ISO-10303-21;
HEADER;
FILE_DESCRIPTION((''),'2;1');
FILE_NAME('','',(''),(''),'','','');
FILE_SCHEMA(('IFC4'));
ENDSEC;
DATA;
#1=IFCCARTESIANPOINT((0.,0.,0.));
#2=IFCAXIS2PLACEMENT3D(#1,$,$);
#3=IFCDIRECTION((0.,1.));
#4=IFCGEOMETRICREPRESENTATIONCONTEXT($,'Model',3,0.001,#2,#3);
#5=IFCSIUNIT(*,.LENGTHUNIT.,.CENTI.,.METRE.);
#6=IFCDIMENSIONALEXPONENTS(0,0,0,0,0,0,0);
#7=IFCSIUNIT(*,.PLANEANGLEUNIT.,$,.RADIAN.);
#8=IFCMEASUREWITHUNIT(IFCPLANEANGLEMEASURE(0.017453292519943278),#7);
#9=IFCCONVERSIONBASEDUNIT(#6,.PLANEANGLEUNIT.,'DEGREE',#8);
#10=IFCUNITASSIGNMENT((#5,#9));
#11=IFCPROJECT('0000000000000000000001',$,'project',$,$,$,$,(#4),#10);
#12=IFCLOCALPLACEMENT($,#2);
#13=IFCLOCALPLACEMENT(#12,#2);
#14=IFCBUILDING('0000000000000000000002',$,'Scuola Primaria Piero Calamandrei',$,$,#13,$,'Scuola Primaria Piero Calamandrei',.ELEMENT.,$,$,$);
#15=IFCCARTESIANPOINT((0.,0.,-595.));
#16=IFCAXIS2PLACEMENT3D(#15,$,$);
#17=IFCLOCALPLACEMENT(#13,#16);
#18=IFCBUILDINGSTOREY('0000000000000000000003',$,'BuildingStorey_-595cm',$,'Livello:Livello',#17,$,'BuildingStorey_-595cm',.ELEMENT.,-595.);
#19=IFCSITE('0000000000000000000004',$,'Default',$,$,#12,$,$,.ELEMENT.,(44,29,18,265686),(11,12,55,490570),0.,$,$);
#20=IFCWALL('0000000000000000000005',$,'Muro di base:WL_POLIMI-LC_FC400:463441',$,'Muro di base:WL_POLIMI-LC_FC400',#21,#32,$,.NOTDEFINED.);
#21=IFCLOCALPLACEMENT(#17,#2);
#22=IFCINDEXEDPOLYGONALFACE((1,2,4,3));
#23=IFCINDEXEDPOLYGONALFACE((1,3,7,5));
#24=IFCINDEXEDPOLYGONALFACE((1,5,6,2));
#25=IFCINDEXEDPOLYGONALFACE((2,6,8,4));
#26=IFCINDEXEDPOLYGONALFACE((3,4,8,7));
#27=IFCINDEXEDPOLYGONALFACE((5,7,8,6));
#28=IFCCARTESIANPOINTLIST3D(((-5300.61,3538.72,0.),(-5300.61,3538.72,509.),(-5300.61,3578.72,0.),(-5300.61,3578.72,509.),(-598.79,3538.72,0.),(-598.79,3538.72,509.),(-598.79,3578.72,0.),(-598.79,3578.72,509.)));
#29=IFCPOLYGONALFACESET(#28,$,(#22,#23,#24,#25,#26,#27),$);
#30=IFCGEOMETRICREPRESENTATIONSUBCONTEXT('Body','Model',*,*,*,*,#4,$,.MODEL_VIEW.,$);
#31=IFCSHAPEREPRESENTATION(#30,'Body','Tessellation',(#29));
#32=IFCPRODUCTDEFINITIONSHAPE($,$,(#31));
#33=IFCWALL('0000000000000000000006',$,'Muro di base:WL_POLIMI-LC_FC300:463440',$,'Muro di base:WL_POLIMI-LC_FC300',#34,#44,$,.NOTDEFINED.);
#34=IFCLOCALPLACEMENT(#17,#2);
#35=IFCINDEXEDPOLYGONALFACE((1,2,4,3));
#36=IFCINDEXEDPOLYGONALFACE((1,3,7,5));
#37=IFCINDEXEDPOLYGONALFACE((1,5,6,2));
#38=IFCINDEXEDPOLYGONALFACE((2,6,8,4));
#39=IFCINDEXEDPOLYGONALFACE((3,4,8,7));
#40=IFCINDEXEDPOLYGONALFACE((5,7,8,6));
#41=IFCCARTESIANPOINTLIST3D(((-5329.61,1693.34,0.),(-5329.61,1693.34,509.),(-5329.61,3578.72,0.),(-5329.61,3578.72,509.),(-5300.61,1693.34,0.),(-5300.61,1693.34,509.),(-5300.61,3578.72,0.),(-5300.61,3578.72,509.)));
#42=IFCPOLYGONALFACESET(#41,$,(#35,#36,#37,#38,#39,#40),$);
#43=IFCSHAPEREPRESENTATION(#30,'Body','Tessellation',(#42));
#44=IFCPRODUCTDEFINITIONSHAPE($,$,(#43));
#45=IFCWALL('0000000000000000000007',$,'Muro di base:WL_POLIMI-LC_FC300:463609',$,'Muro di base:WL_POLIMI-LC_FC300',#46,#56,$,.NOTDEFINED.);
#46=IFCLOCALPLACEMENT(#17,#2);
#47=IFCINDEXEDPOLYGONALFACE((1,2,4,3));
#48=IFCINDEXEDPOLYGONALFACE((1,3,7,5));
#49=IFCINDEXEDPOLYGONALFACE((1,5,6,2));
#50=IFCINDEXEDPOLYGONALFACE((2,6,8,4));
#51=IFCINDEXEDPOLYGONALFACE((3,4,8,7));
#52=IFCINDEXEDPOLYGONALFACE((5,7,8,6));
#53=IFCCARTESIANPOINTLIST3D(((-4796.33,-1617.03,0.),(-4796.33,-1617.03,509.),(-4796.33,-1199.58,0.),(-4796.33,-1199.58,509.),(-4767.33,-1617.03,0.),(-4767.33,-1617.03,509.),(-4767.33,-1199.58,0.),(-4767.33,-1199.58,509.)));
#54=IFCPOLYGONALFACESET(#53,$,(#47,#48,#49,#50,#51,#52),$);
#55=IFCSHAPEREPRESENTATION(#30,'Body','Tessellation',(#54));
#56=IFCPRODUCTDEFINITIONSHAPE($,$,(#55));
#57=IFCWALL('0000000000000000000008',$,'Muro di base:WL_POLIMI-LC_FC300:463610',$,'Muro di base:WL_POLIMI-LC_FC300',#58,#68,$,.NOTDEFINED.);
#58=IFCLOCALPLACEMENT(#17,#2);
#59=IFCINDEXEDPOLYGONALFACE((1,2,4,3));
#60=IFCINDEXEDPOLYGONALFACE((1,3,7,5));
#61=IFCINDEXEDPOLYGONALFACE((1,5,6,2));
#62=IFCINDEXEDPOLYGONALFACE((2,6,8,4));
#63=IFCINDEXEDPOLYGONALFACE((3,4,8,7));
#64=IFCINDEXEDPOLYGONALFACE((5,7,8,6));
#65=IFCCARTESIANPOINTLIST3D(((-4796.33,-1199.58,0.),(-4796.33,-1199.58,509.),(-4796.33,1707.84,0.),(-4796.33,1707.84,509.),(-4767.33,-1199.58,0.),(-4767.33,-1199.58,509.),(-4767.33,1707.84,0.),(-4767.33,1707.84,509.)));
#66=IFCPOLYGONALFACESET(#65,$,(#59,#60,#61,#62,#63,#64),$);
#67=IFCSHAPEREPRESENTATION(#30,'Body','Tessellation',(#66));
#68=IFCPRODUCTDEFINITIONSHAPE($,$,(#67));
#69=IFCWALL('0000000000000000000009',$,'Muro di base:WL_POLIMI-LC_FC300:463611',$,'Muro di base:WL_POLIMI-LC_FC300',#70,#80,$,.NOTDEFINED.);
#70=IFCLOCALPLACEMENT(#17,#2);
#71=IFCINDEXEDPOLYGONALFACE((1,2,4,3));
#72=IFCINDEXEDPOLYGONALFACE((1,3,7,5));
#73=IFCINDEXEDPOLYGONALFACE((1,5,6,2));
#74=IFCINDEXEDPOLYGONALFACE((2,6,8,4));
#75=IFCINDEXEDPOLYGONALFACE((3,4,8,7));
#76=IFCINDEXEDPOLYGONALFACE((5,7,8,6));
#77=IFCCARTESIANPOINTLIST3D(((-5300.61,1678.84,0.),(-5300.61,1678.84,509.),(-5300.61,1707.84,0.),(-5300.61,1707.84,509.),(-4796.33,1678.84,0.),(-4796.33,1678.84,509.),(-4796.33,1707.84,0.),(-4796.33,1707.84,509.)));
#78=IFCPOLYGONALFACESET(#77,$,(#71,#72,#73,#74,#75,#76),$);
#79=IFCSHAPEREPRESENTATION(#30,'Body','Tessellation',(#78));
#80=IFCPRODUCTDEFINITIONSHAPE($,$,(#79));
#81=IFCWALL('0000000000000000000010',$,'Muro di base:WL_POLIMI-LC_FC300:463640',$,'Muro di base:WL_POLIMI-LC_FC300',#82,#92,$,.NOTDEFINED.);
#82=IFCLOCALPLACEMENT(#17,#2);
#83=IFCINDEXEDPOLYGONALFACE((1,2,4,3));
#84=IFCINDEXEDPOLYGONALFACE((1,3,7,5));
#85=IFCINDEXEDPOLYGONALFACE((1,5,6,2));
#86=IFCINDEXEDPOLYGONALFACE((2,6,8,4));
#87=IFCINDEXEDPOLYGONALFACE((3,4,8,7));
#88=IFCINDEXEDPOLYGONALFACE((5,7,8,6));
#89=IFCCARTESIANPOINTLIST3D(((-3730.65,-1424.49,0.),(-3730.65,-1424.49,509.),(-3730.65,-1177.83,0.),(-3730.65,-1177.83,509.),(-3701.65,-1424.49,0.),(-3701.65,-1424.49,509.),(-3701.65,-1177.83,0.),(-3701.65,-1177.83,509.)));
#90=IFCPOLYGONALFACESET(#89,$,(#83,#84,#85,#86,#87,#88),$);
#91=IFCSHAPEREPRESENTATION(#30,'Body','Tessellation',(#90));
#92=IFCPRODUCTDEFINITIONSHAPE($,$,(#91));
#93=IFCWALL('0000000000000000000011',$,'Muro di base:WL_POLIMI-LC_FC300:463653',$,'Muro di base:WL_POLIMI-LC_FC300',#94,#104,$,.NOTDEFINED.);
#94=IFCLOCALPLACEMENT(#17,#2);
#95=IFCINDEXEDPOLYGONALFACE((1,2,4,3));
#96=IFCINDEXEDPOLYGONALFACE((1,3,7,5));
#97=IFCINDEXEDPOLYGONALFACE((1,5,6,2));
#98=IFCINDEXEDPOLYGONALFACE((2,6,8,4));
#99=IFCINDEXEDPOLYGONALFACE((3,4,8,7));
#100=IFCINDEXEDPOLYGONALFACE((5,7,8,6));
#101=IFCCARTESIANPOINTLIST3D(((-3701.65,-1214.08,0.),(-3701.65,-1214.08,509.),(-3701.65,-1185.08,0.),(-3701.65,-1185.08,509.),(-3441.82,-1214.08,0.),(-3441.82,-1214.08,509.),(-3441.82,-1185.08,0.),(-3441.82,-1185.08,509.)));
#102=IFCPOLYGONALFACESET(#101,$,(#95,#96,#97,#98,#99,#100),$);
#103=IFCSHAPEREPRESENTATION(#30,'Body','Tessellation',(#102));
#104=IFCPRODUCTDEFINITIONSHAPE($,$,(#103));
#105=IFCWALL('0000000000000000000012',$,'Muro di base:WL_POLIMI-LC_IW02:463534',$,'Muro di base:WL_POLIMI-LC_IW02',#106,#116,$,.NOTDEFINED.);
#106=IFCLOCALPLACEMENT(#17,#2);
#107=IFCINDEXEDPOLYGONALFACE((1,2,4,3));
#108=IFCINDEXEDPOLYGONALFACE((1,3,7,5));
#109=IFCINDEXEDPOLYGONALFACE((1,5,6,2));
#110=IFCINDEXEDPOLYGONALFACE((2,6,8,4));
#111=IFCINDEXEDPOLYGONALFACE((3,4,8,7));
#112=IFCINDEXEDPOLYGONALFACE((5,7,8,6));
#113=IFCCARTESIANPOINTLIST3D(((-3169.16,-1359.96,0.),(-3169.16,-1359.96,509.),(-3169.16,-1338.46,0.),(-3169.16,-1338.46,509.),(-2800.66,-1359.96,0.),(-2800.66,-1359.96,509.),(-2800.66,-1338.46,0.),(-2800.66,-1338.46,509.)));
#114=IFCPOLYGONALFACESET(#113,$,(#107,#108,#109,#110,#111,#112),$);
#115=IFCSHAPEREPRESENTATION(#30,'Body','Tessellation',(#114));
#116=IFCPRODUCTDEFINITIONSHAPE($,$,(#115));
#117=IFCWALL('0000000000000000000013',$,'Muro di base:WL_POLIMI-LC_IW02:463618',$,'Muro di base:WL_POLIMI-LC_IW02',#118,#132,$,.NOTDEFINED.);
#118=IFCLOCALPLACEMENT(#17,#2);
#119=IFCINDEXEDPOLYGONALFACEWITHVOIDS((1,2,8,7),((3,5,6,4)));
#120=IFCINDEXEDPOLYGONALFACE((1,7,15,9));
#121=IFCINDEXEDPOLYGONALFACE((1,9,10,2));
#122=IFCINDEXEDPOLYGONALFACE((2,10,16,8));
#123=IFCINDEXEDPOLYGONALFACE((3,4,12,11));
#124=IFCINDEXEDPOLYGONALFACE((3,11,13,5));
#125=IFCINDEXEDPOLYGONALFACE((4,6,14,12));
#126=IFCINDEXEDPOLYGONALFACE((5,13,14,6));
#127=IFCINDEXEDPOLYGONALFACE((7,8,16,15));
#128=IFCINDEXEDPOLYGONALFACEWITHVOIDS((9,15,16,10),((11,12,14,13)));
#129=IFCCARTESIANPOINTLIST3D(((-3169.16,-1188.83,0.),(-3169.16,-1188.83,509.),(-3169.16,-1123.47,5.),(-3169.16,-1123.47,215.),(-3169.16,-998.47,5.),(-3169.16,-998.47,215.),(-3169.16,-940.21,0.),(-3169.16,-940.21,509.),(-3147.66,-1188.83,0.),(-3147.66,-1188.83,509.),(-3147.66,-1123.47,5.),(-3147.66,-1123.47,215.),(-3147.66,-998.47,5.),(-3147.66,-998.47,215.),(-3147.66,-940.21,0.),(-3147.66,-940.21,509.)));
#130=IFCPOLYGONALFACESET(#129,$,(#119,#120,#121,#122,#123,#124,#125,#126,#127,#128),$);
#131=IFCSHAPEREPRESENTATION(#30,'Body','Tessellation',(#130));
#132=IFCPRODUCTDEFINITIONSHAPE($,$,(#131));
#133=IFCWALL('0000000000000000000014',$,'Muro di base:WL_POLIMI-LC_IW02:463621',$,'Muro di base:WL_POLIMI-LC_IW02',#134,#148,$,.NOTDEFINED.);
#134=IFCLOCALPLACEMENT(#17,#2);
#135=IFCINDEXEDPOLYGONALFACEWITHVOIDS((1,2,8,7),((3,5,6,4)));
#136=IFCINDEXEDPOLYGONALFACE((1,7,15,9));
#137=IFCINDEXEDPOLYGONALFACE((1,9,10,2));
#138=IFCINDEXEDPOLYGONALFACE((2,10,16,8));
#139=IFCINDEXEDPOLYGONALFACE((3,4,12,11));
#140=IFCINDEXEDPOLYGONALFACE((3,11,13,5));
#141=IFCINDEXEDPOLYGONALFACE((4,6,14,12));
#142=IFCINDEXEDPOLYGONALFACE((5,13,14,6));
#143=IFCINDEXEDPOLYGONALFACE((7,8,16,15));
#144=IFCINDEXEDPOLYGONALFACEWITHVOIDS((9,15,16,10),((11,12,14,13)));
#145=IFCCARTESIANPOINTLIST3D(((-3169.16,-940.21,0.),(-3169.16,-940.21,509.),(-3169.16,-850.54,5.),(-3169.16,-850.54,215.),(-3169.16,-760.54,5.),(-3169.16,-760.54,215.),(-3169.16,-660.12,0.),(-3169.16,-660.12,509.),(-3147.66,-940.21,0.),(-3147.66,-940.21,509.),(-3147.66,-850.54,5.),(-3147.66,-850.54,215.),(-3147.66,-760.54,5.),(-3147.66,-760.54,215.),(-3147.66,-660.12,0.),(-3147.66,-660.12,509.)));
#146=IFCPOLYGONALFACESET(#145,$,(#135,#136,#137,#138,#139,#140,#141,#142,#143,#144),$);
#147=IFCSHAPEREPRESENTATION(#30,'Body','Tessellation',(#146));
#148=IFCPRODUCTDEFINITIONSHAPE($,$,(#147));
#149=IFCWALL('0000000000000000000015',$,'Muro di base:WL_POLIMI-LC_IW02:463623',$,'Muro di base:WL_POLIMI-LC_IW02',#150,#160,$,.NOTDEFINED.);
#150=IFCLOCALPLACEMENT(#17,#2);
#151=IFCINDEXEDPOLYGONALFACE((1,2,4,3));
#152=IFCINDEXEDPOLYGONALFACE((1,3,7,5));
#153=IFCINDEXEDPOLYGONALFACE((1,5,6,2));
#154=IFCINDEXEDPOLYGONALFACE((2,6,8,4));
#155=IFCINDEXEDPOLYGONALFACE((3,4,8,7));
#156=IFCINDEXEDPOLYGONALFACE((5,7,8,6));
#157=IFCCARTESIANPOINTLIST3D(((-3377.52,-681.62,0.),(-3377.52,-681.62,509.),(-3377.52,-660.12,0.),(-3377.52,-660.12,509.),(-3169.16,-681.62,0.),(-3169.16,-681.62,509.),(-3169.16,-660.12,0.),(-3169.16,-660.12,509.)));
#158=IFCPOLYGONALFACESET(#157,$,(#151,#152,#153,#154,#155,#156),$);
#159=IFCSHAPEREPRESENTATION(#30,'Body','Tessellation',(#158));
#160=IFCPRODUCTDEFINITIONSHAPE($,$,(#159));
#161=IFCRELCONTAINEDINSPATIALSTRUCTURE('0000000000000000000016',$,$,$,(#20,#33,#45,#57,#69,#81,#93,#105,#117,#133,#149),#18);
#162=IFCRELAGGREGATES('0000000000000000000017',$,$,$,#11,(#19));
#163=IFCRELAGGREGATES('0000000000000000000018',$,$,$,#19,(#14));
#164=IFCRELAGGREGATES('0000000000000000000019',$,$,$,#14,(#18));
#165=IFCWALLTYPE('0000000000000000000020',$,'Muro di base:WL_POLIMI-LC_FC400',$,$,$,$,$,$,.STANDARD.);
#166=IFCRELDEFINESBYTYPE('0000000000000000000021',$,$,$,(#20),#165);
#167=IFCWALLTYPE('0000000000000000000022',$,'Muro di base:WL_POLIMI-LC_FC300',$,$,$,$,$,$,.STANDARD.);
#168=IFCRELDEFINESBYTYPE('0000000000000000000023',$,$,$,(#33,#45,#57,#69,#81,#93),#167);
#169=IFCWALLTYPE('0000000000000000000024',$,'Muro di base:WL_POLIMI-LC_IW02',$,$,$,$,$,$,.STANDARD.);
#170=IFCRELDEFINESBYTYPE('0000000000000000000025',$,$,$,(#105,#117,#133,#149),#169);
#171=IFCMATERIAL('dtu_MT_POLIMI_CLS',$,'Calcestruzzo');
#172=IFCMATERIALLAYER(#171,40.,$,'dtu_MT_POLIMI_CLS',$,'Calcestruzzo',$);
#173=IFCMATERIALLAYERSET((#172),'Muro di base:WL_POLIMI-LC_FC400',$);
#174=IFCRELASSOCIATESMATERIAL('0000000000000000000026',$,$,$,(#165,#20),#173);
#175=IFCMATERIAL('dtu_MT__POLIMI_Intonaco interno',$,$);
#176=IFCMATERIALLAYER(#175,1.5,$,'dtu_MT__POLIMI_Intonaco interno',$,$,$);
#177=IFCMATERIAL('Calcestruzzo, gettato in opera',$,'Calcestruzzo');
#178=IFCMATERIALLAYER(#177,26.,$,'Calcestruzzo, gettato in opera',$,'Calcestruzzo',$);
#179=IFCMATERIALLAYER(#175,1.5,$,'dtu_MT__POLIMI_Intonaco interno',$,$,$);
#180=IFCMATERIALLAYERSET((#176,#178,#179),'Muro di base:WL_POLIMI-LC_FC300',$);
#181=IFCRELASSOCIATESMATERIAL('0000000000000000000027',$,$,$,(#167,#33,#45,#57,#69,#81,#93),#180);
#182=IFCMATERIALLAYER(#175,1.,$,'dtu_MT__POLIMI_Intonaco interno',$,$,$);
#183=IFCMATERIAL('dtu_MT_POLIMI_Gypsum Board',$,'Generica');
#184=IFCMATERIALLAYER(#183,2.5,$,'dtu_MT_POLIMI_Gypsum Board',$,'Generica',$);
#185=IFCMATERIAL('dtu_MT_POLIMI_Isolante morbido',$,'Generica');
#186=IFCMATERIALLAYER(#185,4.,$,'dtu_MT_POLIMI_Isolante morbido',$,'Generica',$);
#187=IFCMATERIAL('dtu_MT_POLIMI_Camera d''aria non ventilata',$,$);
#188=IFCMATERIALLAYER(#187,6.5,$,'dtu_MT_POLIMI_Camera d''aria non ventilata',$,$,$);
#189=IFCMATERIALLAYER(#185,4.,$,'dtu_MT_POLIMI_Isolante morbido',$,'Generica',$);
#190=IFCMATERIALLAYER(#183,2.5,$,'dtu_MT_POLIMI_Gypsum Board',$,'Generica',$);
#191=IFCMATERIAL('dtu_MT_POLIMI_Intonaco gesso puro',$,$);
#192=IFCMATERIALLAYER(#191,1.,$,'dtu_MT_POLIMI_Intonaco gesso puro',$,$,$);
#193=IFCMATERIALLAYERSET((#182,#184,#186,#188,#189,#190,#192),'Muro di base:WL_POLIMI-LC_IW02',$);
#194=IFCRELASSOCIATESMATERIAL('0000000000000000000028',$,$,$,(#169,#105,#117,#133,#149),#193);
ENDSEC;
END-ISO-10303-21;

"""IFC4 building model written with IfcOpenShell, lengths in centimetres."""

from ifc_helpers import new_model, entity, si_unit, converted_unit, direction, frame, frame_2d, origin, place, context, subcontext, project, spatial, polyline, rectangle, extrude, clip, bounded_halfspace, material, layer, layer_set, layer_usage, type_object, element, save


model = new_model("IFC4")

# Units and contexts
model_context = context("Model", 3, precision=0.001, world=origin(), true_north=direction((0.0, 1.0)))
body_context = subcontext(model_context, "Body", "Model", "MODEL_VIEW")
ifc_project = project(units=[si_unit("LENGTHUNIT", "METRE", prefix="CENTI"), converted_unit("PLANEANGLEUNIT", "DEGREE", entity("IfcPlaneAngleMeasure", 0.017453292519943278), si_unit("PLANEANGLEUNIT", "RADIAN"), dimensions=[0, 0, 0, 0, 0, 0, 0])], contexts=[model_context])

# Site, building, storey
site_placement = place(None, origin())
site = spatial("IfcSite", under=ifc_project, at=site_placement, Name="Default", CompositionType="ELEMENT", RefLatitude=(44, 29, 18, 265686), RefLongitude=(11, 12, 55, 490570), RefElevation=0.0)
building_placement = place(site_placement, origin())
building = spatial("IfcBuilding", under=site, at=building_placement, Name="Scuola Primaria Piero Calamandrei", LongName="Scuola Primaria Piero Calamandrei", CompositionType="ELEMENT")
storey_placement = place(building_placement, frame((0.0, 0.0, -595.0)))
storey = spatial("IfcBuildingStorey", under=building, at=storey_placement, Name="BuildingStorey_-595cm", ObjectType="Livello:Livello", LongName="BuildingStorey_-595cm", CompositionType="ELEMENT", Elevation=-595.0)

# Walls
ifc_material_1 = material(Name="dtu_MT_POLIMI_CLS", Category="Calcestruzzo")
ifc_layer_1 = layer(ifc_material_1, 40.0, Name="dtu_MT_POLIMI_CLS", Category="Calcestruzzo")
ifc_layer_set_1 = layer_set([ifc_layer_1], Name="Muro di base:WL_POLIMI-LC_FC400")
ifc_layer_usage_1 = layer_usage(ifc_layer_set_1, "AXIS2", "NEGATIVE", 20.0)
wall_type_1 = type_object("IfcWallType", Name="Muro di base:WL_POLIMI-LC_FC400", PredefinedType="STANDARD", material=ifc_layer_set_1)
wall_1_placement = place(storey_placement, frame((-5300.61, 3558.72, 0.0)))
element("IfcWall", 1, at=wall_1_placement, inside=storey, type_object=wall_type_1, material=ifc_layer_usage_1, Name="Muro di base:WL_POLIMI-LC_FC400:463441", ObjectType="Muro di base:WL_POLIMI-LC_FC400", PredefinedType="NOTDEFINED", context=body_context, shape_type="Clipping", body=[
    clip(extrude(rectangle(XDim=4701.82, YDim=40.0, at=frame_2d((2350.91, 0.0), x_axis=(-1.0, 0.0))), origin(), (0.0, 0.0, 1.0), 509.0), bounded_halfspace(frame((0.0, -20.0, 509.0)), False, frame((0.0, -20.0, 509.0)), polyline([(0.0, 0.0), (4656.82, 0.0), (4701.82, 0.0), (4701.82, 40.0), (0.0, 40.0), (0.0, 0.0)]))),
])
ifc_material_2 = material(Name="dtu_MT__POLIMI_Intonaco interno")
ifc_layer_2 = layer(ifc_material_2, 1.5, Name="dtu_MT__POLIMI_Intonaco interno")
ifc_material_3 = material(Name="Calcestruzzo, gettato in opera", Category="Calcestruzzo")
ifc_layer_3 = layer(ifc_material_3, 26.0, Name="Calcestruzzo, gettato in opera", Category="Calcestruzzo")
ifc_layer_4 = layer(ifc_material_2, 1.5, Name="dtu_MT__POLIMI_Intonaco interno")
ifc_layer_set_2 = layer_set([ifc_layer_2, ifc_layer_3, ifc_layer_4], Name="Muro di base:WL_POLIMI-LC_FC300")
ifc_layer_usage_2 = layer_usage(ifc_layer_set_2, "AXIS2", "NEGATIVE", 14.5)
wall_type_2 = type_object("IfcWallType", Name="Muro di base:WL_POLIMI-LC_FC300", PredefinedType="STANDARD", material=ifc_layer_set_2)
wall_2_placement = place(storey_placement, frame((-5315.11, 1693.34, 0.0), z_axis=(0.0, 0.0, 1.0), x_axis=(0.0, 1.0, 0.0)))
element("IfcWall", 2, at=wall_2_placement, inside=storey, type_object=wall_type_2, material=ifc_layer_usage_2, Name="Muro di base:WL_POLIMI-LC_FC300:463440", ObjectType="Muro di base:WL_POLIMI-LC_FC300", PredefinedType="NOTDEFINED", context=body_context, shape_type="Clipping", body=[
    clip(extrude(rectangle(XDim=1885.38, YDim=29.0, at=frame_2d((942.69, 0.0), x_axis=(-1.0, 0.0))), origin(), (0.0, 0.0, 1.0), 509.0), bounded_halfspace(frame((0.0, -14.5, 509.0), z_axis=(0.0, 0.0, 1.0), x_axis=(0.0, -1.0, 0.0)), False, frame((0.0, -14.5, 509.0)), polyline([(0.0, 0.0), (14.5, 0.0), (1845.38, 0.0), (1885.38, 0.0), (1885.38, 29.0), (0.0, 29.0), (0.0, 0.0)]))),
])
ifc_layer_usage_3 = layer_usage(ifc_layer_set_2, "AXIS2", "NEGATIVE", 14.5)
wall_3_placement = place(storey_placement, frame((-4781.83, -1199.58, 0.0), z_axis=(0.0, 0.0, 1.0), x_axis=(0.0, -1.0, 0.0)))
element("IfcWall", 3, at=wall_3_placement, inside=storey, type_object=wall_type_2, material=ifc_layer_usage_3, Name="Muro di base:WL_POLIMI-LC_FC300:463609", ObjectType="Muro di base:WL_POLIMI-LC_FC300", PredefinedType="NOTDEFINED", context=body_context, shape_type="SweptSolid", body=[
    extrude(rectangle(XDim=417.45, YDim=29.0, at=frame_2d((208.72, 0.0), x_axis=(-1.0, 0.0))), origin(), (0.0, 0.0, 1.0), 509.0),
])
ifc_layer_usage_4 = layer_usage(ifc_layer_set_2, "AXIS2", "NEGATIVE", 14.5)
wall_4_placement = place(storey_placement, frame((-4781.83, 1707.84, 0.0), z_axis=(0.0, 0.0, 1.0), x_axis=(0.0, -1.0, 0.0)))
element("IfcWall", 4, at=wall_4_placement, inside=storey, type_object=wall_type_2, material=ifc_layer_usage_4, Name="Muro di base:WL_POLIMI-LC_FC300:463610", ObjectType="Muro di base:WL_POLIMI-LC_FC300", PredefinedType="NOTDEFINED", context=body_context, shape_type="SweptSolid", body=[
    extrude(rectangle(XDim=2907.41, YDim=29.0, at=frame_2d((1453.71, 0.0), x_axis=(-1.0, 0.0))), origin(), (0.0, 0.0, 1.0), 509.0),
])
ifc_layer_usage_5 = layer_usage(ifc_layer_set_2, "AXIS2", "NEGATIVE", 14.5)
wall_5_placement = place(storey_placement, frame((-5300.61, 1693.34, 0.0)))
element("IfcWall", 5, at=wall_5_placement, inside=storey, type_object=wall_type_2, material=ifc_layer_usage_5, Name="Muro di base:WL_POLIMI-LC_FC300:463611", ObjectType="Muro di base:WL_POLIMI-LC_FC300", PredefinedType="NOTDEFINED", context=body_context, shape_type="SweptSolid", body=[
    extrude(rectangle(XDim=504.28, YDim=29.0, at=frame_2d((252.14, 0.0), x_axis=(-1.0, 0.0))), origin(), (0.0, 0.0, 1.0), 509.0),
])
ifc_layer_usage_6 = layer_usage(ifc_layer_set_2, "AXIS2", "NEGATIVE", 14.5)
wall_6_placement = place(storey_placement, frame((-3716.15, -1177.83, 0.0), z_axis=(0.0, 0.0, 1.0), x_axis=(0.0, -1.0, 0.0)))
element("IfcWall", 6, at=wall_6_placement, inside=storey, type_object=wall_type_2, material=ifc_layer_usage_6, Name="Muro di base:WL_POLIMI-LC_FC300:463640", ObjectType="Muro di base:WL_POLIMI-LC_FC300", PredefinedType="NOTDEFINED", context=body_context, shape_type="SweptSolid", body=[
    extrude(rectangle(XDim=246.66, YDim=29.0, at=frame_2d((123.33, 0.0), x_axis=(-1.0, 0.0))), origin(), (0.0, 0.0, 1.0), 509.0),
])
ifc_layer_usage_7 = layer_usage(ifc_layer_set_2, "AXIS2", "NEGATIVE", 14.5)
wall_7_placement = place(storey_placement, frame((-3441.82, -1199.58, 0.0), z_axis=(0.0, 0.0, 1.0), x_axis=(-1.0, 0.0, 0.0)))
element("IfcWall", 7, at=wall_7_placement, inside=storey, type_object=wall_type_2, material=ifc_layer_usage_7, Name="Muro di base:WL_POLIMI-LC_FC300:463653", ObjectType="Muro di base:WL_POLIMI-LC_FC300", PredefinedType="NOTDEFINED", context=body_context, shape_type="SweptSolid", body=[
    extrude(rectangle(XDim=259.83, YDim=29.0, at=frame_2d((129.91, 0.0), x_axis=(-1.0, 0.0))), origin(), (0.0, 0.0, 1.0), 509.0),
])
ifc_layer_5 = layer(ifc_material_2, 1.0, Name="dtu_MT__POLIMI_Intonaco interno")
ifc_material_4 = material(Name="dtu_MT_POLIMI_Gypsum Board", Category="Generica")
ifc_layer_6 = layer(ifc_material_4, 2.5, Name="dtu_MT_POLIMI_Gypsum Board", Category="Generica")
ifc_material_5 = material(Name="dtu_MT_POLIMI_Isolante morbido", Category="Generica")
ifc_layer_7 = layer(ifc_material_5, 4.0, Name="dtu_MT_POLIMI_Isolante morbido", Category="Generica")
ifc_material_6 = material(Name="dtu_MT_POLIMI_Camera d'aria non ventilata")
ifc_layer_8 = layer(ifc_material_6, 6.5, Name="dtu_MT_POLIMI_Camera d'aria non ventilata")
ifc_layer_9 = layer(ifc_material_5, 4.0, Name="dtu_MT_POLIMI_Isolante morbido", Category="Generica")
ifc_layer_10 = layer(ifc_material_4, 2.5, Name="dtu_MT_POLIMI_Gypsum Board", Category="Generica")
ifc_material_7 = material(Name="dtu_MT_POLIMI_Intonaco gesso puro")
ifc_layer_11 = layer(ifc_material_7, 1.0, Name="dtu_MT_POLIMI_Intonaco gesso puro")
ifc_layer_set_3 = layer_set([ifc_layer_5, ifc_layer_6, ifc_layer_7, ifc_layer_8, ifc_layer_9, ifc_layer_10, ifc_layer_11], Name="Muro di base:WL_POLIMI-LC_IW02")
ifc_layer_usage_8 = layer_usage(ifc_layer_set_3, "AXIS2", "NEGATIVE", 10.75)
wall_type_3 = type_object("IfcWallType", Name="Muro di base:WL_POLIMI-LC_IW02", PredefinedType="STANDARD", material=ifc_layer_set_3)
wall_8_placement = place(storey_placement, frame((-3169.16, -1349.21, 0.0)))
element("IfcWall", 8, at=wall_8_placement, inside=storey, type_object=wall_type_3, material=ifc_layer_usage_8, Name="Muro di base:WL_POLIMI-LC_IW02:463534", ObjectType="Muro di base:WL_POLIMI-LC_IW02", PredefinedType="NOTDEFINED", context=body_context, shape_type="SweptSolid", body=[
    extrude(rectangle(XDim=368.51, YDim=21.5, at=frame_2d((184.25, 0.0), x_axis=(-1.0, 0.0))), origin(), (0.0, 0.0, 1.0), 509.0),
])

# Walls, openings
ifc_layer_usage_9 = layer_usage(ifc_layer_set_3, "AXIS2", "NEGATIVE", 10.75)
wall_9_placement = place(storey_placement, frame((-3158.41, -1188.83, 0.0), z_axis=(0.0, 0.0, 1.0), x_axis=(0.0, 1.0, 0.0)))
wall_9 = element("IfcWall", 9, at=wall_9_placement, inside=storey, type_object=wall_type_3, material=ifc_layer_usage_9, Name="Muro di base:WL_POLIMI-LC_IW02:463618", ObjectType="Muro di base:WL_POLIMI-LC_IW02", PredefinedType="NOTDEFINED", context=body_context, shape_type="SweptSolid", body=[
    extrude(rectangle(XDim=248.61, YDim=21.5, at=frame_2d((124.31, 0.0), x_axis=(-1.0, 0.0))), origin(), (0.0, 0.0, 1.0), 509.0),
])
opening_1_placement = place(wall_9_placement, frame((65.36, -10.75, 5.0)))
element("IfcOpeningElement", 10, at=opening_1_placement, cuts=wall_9, PredefinedType="OPENING", context=body_context, shape_type="SweptSolid", body=[
    extrude(rectangle(XDim=210.0, YDim=125.0, at=frame_2d((105.0, 62.5), x_axis=(-1.0, 0.0))), frame((0.0, 0.0, 0.0), z_axis=(0.0, 1.0, 0.0), x_axis=(0.0, 0.0, 1.0)), (0.0, 0.0, 1.0), 21.5),
])
ifc_layer_usage_10 = layer_usage(ifc_layer_set_3, "AXIS2", "NEGATIVE", 10.75)
wall_10_placement = place(storey_placement, frame((-3158.41, -940.21, 0.0), z_axis=(0.0, 0.0, 1.0), x_axis=(0.0, 1.0, 0.0)))
wall_10 = element("IfcWall", 11, at=wall_10_placement, inside=storey, type_object=wall_type_3, material=ifc_layer_usage_10, Name="Muro di base:WL_POLIMI-LC_IW02:463621", ObjectType="Muro di base:WL_POLIMI-LC_IW02", PredefinedType="NOTDEFINED", context=body_context, shape_type="SweptSolid", body=[
    extrude(rectangle(XDim=280.09, YDim=21.5, at=frame_2d((140.05, 0.0), x_axis=(-1.0, 0.0))), origin(), (0.0, 0.0, 1.0), 509.0),
])
opening_2_placement = place(wall_10_placement, frame((179.67, 10.75, 5.0)))
element("IfcOpeningElement", 12, at=opening_2_placement, cuts=wall_10, PredefinedType="OPENING", context=body_context, shape_type="SweptSolid", body=[
    extrude(rectangle(XDim=210.0, YDim=90.0, at=frame_2d((105.0, 45.0), x_axis=(1.0, 0.0))), frame((0.0, 0.0, 0.0), z_axis=(0.0, -1.0, 0.0), x_axis=(0.0, 0.0, 1.0)), (0.0, 0.0, 1.0), 21.5),
])

# Wall
ifc_layer_usage_11 = layer_usage(ifc_layer_set_3, "AXIS2", "NEGATIVE", 10.75)
wall_11_placement = place(storey_placement, frame((-3169.16, -670.87, 0.0), z_axis=(0.0, 0.0, 1.0), x_axis=(-1.0, 0.0, 0.0)))
element("IfcWall", 13, at=wall_11_placement, inside=storey, type_object=wall_type_3, material=ifc_layer_usage_11, Name="Muro di base:WL_POLIMI-LC_IW02:463623", ObjectType="Muro di base:WL_POLIMI-LC_IW02", PredefinedType="NOTDEFINED", context=body_context, shape_type="SweptSolid", body=[
    extrude(rectangle(XDim=208.36, YDim=21.5, at=frame_2d((104.18, 0.0), x_axis=(-1.0, 0.0))), origin(), (0.0, 0.0, 1.0), 509.0),
])

save(model, "model.ifc")
